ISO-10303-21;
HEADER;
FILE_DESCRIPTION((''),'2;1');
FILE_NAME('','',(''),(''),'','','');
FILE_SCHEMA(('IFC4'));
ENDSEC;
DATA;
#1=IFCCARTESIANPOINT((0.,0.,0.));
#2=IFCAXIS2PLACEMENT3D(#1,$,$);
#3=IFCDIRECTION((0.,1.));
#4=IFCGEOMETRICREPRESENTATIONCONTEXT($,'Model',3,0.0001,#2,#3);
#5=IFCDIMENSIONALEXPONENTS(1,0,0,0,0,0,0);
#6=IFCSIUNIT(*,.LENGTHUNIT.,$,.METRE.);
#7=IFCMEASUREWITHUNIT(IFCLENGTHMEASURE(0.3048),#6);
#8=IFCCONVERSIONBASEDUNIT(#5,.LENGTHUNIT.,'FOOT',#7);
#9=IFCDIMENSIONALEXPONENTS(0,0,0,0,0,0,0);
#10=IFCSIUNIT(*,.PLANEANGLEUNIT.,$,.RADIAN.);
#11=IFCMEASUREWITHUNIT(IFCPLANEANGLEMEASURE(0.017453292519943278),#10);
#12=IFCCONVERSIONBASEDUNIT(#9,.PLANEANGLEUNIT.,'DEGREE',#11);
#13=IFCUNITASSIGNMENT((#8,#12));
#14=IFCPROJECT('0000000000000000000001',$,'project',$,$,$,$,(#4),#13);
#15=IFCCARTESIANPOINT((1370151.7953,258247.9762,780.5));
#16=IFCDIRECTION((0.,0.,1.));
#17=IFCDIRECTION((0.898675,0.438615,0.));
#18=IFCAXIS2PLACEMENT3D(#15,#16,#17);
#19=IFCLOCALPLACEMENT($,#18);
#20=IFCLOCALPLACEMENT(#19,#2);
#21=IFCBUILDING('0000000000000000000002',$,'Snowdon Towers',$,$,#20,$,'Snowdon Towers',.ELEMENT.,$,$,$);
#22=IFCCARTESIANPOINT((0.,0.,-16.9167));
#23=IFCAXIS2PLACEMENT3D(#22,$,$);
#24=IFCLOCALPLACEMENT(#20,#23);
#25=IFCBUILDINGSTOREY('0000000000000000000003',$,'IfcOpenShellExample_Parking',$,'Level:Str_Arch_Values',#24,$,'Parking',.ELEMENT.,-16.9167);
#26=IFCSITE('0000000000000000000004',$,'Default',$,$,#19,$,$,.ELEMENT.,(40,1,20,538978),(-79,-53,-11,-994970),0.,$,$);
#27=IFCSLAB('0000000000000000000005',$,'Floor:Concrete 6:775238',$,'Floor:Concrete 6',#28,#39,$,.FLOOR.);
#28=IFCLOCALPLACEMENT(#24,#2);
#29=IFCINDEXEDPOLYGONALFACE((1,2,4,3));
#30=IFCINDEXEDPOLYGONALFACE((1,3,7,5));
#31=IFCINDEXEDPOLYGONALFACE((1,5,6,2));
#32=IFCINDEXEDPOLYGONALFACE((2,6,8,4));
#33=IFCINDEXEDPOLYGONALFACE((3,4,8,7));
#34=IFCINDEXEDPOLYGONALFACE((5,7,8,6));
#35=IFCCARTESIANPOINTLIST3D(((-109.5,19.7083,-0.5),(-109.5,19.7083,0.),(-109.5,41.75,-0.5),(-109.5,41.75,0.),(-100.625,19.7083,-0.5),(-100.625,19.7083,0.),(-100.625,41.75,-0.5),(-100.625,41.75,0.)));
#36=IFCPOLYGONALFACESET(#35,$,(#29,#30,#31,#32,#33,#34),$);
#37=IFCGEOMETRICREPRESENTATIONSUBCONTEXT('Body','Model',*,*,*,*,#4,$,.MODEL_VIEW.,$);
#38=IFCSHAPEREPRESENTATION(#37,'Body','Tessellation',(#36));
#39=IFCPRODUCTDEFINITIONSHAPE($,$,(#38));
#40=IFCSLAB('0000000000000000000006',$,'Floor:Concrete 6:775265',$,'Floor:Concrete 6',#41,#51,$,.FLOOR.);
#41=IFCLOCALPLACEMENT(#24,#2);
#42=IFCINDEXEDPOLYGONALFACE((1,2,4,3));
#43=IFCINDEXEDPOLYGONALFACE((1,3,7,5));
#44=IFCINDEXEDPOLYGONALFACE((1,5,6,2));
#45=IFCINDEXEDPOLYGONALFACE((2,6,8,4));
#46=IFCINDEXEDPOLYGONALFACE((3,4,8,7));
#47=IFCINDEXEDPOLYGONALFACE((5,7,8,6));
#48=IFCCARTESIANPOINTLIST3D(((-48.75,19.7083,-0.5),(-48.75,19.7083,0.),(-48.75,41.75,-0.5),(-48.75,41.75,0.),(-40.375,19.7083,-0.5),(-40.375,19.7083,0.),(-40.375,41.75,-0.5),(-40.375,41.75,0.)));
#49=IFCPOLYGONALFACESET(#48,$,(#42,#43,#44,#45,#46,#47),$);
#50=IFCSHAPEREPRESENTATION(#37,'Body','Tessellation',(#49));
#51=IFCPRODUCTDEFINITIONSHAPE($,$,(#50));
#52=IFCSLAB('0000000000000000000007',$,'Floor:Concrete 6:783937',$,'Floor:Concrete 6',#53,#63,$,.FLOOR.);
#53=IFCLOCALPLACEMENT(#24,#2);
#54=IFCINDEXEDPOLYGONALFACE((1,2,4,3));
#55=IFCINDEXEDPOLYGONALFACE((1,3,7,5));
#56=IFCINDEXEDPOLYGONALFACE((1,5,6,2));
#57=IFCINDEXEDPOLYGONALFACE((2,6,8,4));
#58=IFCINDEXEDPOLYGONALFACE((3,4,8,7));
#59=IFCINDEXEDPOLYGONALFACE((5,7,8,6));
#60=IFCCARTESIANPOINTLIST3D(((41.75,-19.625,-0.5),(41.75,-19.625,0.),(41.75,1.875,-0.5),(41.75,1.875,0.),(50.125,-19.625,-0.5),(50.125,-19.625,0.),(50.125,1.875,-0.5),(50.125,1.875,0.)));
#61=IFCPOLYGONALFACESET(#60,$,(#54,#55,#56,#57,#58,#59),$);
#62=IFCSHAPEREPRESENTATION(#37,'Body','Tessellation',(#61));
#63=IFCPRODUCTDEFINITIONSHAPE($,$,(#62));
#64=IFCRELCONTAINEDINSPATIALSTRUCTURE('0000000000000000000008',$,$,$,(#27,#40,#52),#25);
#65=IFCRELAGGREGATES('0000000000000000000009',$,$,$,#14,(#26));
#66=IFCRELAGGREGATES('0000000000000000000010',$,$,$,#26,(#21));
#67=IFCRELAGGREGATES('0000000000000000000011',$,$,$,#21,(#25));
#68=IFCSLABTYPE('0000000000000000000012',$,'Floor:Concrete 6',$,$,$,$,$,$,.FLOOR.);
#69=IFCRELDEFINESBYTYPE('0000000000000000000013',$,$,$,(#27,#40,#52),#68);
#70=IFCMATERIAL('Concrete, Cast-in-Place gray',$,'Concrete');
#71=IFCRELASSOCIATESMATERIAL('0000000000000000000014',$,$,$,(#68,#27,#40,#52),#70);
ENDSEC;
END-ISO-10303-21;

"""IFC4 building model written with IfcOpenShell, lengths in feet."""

from ifc_helpers import new_model, entity, si_unit, converted_unit, direction, frame, origin, place, context, subcontext, project, spatial, indexed_curve, outline, extrude, material, type_object, element, save


model = new_model("IFC4")

# Units and contexts
model_context = context("Model", 3, precision=0.0001, world=origin(), true_north=direction((0.0, 1.0)))
body_context = subcontext(model_context, "Body", "Model", "MODEL_VIEW")
ifc_project = project(units=[converted_unit("LENGTHUNIT", "FOOT", entity("IfcLengthMeasure", 0.3048), si_unit("LENGTHUNIT", "METRE"), dimensions=[1, 0, 0, 0, 0, 0, 0]), converted_unit("PLANEANGLEUNIT", "DEGREE", entity("IfcPlaneAngleMeasure", 0.017453292519943278), si_unit("PLANEANGLEUNIT", "RADIAN"), dimensions=[0, 0, 0, 0, 0, 0, 0])], contexts=[model_context])

# Site, building, storey
site_placement = place(None, frame((1370151.7953, 258247.9762, 780.5), z_axis=(0.0, 0.0, 1.0), x_axis=(0.898675, 0.438615, 0.0)))
site = spatial("IfcSite", under=ifc_project, at=site_placement, Name="Default", CompositionType="ELEMENT", RefLatitude=(40, 1, 20, 538978), RefLongitude=(-79, -53, -11, -994970), RefElevation=0.0)
building_placement = place(site_placement, origin())
building = spatial("IfcBuilding", under=site, at=building_placement, Name="Snowdon Towers", LongName="Snowdon Towers", CompositionType="ELEMENT")
storey_placement = place(building_placement, frame((0.0, 0.0, -16.9167)))
storey = spatial("IfcBuildingStorey", under=building, at=storey_placement, Name="IfcOpenShellExample_Parking", ObjectType="Level:Str_Arch_Values", LongName="Parking", CompositionType="ELEMENT", Elevation=-16.9167)

# Shared definitions
ifc_material = material(Name="Concrete, Cast-in-Place gray", Category="Concrete")

# Shared definitions
slab_type_1 = type_object("IfcSlabType", Name="Floor:Concrete 6", PredefinedType="FLOOR", material=ifc_material)

# Slabs
slab_1_placement = place(storey_placement, origin())
element("IfcSlab", 1, at=slab_1_placement, inside=storey, type_object=slab_type_1, material=ifc_material, Name="Floor:Concrete 6:775238", ObjectType="Floor:Concrete 6", PredefinedType="FLOOR", context=body_context, shape_type="SweptSolid", body=[
    extrude(outline(indexed_curve([(-11.0208, -4.4375), (11.0208, -4.4375), (11.0208, 4.4375), (-11.0208, 4.4375), (-11.0208, -4.4375)], self_intersect=False)), frame((-105.0625, 30.7292, 0.0), z_axis=(0.0, 0.0, -1.0), x_axis=(0.0, 1.0, 0.0)), (0.0, 0.0, 1.0), 0.5),
])
slab_2_placement = place(storey_placement, origin())
element("IfcSlab", 2, at=slab_2_placement, inside=storey, type_object=slab_type_1, material=ifc_material, Name="Floor:Concrete 6:775265", ObjectType="Floor:Concrete 6", PredefinedType="FLOOR", context=body_context, shape_type="SweptSolid", body=[
    extrude(outline(indexed_curve([(-11.0208, -4.1875), (11.0208, -4.1875), (11.0208, 4.1875), (-11.0208, 4.1875), (-11.0208, -4.1875)], self_intersect=False)), frame((-44.5625, 30.7292, 0.0), z_axis=(0.0, 0.0, -1.0), x_axis=(0.0, 1.0, 0.0)), (0.0, 0.0, 1.0), 0.5),
])
slab_3_placement = place(storey_placement, origin())
element("IfcSlab", 3, at=slab_3_placement, inside=storey, type_object=slab_type_1, material=ifc_material, Name="Floor:Concrete 6:783937", ObjectType="Floor:Concrete 6", PredefinedType="FLOOR", context=body_context, shape_type="SweptSolid", body=[
    extrude(outline(indexed_curve([(-10.75, -4.1875), (10.75, -4.1875), (10.75, 4.1875), (-10.75, 4.1875), (-10.75, -4.1875)], self_intersect=False)), frame((45.9375, -8.875, 0.0), z_axis=(0.0, 0.0, -1.0), x_axis=(0.0, 1.0, 0.0)), (0.0, 0.0, 1.0), 0.5),
])

save(model, "model.ifc")
